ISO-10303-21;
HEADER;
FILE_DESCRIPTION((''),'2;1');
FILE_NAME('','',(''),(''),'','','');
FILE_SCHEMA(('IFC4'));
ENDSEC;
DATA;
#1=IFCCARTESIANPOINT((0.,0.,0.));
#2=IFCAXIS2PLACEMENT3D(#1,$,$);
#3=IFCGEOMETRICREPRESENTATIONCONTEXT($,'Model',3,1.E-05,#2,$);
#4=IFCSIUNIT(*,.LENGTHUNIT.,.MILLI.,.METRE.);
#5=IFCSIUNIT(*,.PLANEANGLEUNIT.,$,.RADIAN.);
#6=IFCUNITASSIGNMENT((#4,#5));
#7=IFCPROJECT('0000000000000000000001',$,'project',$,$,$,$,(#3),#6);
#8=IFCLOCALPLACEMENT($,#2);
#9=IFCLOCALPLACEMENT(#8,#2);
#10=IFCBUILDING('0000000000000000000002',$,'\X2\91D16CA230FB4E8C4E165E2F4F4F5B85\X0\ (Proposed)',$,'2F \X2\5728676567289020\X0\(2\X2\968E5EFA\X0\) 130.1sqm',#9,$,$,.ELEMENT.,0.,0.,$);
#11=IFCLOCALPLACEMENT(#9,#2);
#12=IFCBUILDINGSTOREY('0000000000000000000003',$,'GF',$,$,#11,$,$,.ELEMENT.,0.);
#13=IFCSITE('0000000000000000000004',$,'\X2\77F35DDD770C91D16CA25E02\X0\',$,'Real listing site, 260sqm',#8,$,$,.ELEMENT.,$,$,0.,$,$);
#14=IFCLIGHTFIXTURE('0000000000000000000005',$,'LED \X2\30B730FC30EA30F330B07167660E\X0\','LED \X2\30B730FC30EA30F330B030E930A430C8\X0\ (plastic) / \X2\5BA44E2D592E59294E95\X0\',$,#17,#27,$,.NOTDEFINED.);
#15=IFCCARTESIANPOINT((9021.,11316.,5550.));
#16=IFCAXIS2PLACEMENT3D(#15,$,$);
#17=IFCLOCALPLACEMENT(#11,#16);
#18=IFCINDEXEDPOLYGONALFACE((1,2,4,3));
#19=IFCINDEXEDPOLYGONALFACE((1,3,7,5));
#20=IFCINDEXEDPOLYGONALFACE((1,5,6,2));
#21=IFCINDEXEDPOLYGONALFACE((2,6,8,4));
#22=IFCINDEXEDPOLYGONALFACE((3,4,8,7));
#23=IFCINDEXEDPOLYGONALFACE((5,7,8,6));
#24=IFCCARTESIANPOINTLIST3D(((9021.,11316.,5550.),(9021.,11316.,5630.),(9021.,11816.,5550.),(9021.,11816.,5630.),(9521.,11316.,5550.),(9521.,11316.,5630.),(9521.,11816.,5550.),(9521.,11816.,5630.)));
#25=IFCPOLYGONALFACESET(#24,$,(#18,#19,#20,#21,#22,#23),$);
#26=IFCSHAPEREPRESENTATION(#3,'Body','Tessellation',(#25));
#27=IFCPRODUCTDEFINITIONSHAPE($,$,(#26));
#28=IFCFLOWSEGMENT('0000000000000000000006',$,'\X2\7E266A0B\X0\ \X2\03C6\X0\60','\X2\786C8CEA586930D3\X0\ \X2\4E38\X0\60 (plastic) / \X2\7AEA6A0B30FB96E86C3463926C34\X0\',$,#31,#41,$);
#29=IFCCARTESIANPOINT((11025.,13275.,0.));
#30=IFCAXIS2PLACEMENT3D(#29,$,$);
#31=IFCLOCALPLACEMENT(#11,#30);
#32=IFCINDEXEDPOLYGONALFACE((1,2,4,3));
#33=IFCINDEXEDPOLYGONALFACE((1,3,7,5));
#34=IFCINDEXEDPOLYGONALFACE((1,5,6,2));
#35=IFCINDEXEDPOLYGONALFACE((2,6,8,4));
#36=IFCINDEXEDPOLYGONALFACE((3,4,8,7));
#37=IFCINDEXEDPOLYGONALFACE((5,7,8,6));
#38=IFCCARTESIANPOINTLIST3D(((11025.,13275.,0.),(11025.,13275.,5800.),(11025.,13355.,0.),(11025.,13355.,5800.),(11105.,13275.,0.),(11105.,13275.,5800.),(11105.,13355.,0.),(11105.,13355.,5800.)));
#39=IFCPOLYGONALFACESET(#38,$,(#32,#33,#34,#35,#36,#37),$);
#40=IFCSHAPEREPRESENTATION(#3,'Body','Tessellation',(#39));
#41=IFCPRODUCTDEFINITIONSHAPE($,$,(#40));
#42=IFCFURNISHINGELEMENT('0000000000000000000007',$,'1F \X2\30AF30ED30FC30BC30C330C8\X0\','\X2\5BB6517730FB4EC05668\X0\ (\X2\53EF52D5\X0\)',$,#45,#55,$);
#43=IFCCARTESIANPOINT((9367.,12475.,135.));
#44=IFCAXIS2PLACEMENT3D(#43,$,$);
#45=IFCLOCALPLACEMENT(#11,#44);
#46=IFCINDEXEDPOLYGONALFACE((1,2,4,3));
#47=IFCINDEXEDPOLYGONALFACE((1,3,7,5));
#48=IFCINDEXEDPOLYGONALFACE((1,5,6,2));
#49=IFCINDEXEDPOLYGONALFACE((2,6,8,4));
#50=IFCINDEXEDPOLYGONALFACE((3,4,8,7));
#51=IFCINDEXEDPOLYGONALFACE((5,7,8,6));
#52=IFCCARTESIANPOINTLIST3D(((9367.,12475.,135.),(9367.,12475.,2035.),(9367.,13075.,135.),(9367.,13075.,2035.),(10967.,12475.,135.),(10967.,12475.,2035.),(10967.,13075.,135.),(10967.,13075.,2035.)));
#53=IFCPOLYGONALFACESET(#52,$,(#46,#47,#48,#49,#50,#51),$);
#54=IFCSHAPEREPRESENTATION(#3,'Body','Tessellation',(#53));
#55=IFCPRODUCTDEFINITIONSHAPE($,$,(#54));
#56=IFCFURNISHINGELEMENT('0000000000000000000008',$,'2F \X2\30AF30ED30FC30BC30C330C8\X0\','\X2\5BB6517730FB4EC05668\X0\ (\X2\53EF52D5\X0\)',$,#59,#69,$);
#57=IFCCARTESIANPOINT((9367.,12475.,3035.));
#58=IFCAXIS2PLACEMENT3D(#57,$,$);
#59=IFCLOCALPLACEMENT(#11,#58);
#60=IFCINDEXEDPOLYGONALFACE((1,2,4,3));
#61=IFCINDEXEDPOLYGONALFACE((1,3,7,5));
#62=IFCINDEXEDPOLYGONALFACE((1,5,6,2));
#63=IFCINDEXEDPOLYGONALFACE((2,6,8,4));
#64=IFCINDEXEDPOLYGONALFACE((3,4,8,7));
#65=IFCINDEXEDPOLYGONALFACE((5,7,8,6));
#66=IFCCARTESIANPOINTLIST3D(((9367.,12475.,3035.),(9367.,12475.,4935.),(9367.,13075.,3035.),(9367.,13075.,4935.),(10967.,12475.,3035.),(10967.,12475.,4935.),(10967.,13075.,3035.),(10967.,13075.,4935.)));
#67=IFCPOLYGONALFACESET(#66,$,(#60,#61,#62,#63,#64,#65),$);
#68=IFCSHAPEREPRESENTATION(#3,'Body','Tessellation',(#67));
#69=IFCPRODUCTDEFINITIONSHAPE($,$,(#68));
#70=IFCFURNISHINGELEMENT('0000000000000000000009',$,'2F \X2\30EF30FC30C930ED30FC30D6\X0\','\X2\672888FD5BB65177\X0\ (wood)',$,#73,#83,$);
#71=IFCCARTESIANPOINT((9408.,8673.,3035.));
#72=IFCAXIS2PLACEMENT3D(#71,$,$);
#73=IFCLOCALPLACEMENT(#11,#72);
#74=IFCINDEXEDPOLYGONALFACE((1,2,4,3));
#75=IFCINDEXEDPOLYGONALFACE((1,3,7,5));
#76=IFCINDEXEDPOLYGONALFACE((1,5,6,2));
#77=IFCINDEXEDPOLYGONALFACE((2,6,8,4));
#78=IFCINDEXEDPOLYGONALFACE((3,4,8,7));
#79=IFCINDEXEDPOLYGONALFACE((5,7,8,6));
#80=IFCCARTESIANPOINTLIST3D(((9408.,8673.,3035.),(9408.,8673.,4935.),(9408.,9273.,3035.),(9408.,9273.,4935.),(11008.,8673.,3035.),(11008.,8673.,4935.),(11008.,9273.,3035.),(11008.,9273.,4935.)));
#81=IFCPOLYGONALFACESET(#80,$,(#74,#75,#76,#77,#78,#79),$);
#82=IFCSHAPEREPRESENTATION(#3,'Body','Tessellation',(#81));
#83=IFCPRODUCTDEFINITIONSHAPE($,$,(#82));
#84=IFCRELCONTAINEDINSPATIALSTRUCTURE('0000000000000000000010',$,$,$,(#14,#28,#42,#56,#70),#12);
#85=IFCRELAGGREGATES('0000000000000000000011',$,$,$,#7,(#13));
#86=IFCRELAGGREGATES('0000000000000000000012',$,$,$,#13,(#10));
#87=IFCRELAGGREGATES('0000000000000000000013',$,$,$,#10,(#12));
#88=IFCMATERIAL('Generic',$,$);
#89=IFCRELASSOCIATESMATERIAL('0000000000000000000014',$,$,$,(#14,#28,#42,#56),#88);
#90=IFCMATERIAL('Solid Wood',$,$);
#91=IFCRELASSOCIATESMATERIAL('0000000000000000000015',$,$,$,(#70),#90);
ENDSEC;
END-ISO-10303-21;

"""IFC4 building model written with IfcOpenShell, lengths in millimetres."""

from ifc_helpers import new_model, si_unit, frame, frame_2d, origin, place, context, project, spatial, rectangle, extrude, material, element, save


model = new_model("IFC4")

# Units and contexts
model_context = context("Model", 3, precision=1e-05, world=origin())
ifc_project = project(units=[si_unit("LENGTHUNIT", "METRE", prefix="MILLI"), si_unit("PLANEANGLEUNIT", "RADIAN")], contexts=[model_context])

# Site, building, storey
site_placement = place(None, origin())
site = spatial("IfcSite", under=ifc_project, at=site_placement, Name="石川県金沢市", ObjectType="Real listing site, 260sqm", CompositionType="ELEMENT", RefElevation=0.0)
building_placement = place(site_placement, origin())
building = spatial("IfcBuilding", under=site, at=building_placement, Name="金沢・二世帯住宅 (Proposed)", ObjectType="2F 在来木造(2階建) 130.1sqm", CompositionType="ELEMENT", ElevationOfRefHeight=0.0, ElevationOfTerrain=0.0)
storey_placement = place(building_placement, origin())
storey = spatial("IfcBuildingStorey", under=building, at=storey_placement, Name="GF", CompositionType="ELEMENT", Elevation=0.0)

# Shared definitions
ifc_material_1 = material(Name="Solid Wood")

# Shared definitions
ifc_material_2 = material(Name="Generic")

# Light fixture
light_fixture_1_placement = place(storey_placement, frame((9021.0, 11316.0, 5550.0)))
element("IfcLightFixture", 1, at=light_fixture_1_placement, inside=storey, material=ifc_material_2, Name="LED シーリング照明", Description="LED シーリングライト (plastic) / 室中央天井", PredefinedType="NOTDEFINED", context=model_context, shape_type="SweptSolid", body=[
    extrude(rectangle(XDim=500.0, YDim=500.0, at=frame_2d((250.0, 250.0))), frame((9021.0, 11316.0, 5550.0)), (0.0, 0.0, 1.0), 80.0),
])

# Flow segment
flow_segment_placement = place(storey_placement, frame((11025.0, 13275.0, 0.0)))
element("IfcFlowSegment", 2, at=flow_segment_placement, inside=storey, material=ifc_material_2, Name="縦樋 φ60", Description="硬質塩ビ 丸60 (plastic) / 竪樋・雨水排水", context=model_context, shape_type="SweptSolid", body=[
    extrude(rectangle(XDim=80.0, YDim=80.0, at=frame_2d((40.0, 40.0))), frame((11025.0, 13275.0, 0.0)), (0.0, 0.0, 1.0), 5800.0),
])

# Furnishing elements
furnishing_1_placement = place(storey_placement, frame((9367.0, 12475.0, 135.0)))
element("IfcFurnishingElement", 3, at=furnishing_1_placement, inside=storey, material=ifc_material_2, Name="1F クローゼット", Description="家具・什器 (可動)", context=model_context, shape_type="SweptSolid", body=[
    extrude(rectangle(XDim=1600.0, YDim=600.0, at=frame_2d((800.0, 300.0))), frame((9367.0, 12475.0, 135.0)), (0.0, 0.0, 1.0), 1900.0),
])
furnishing_2_placement = place(storey_placement, frame((9367.0, 12475.0, 3035.0)))
element("IfcFurnishingElement", 4, at=furnishing_2_placement, inside=storey, material=ifc_material_2, Name="2F クローゼット", Description="家具・什器 (可動)", context=model_context, shape_type="SweptSolid", body=[
    extrude(rectangle(XDim=1600.0, YDim=600.0, at=frame_2d((800.0, 300.0))), frame((9367.0, 12475.0, 3035.0)), (0.0, 0.0, 1.0), 1900.0),
])
furnishing_3_placement = place(storey_placement, frame((9408.0, 8673.0, 3035.0)))
element("IfcFurnishingElement", 5, at=furnishing_3_placement, inside=storey, material=ifc_material_1, Name="2F ワードローブ", Description="木製家具 (wood)", context=model_context, shape_type="SweptSolid", body=[
    extrude(rectangle(XDim=1600.0, YDim=600.0, at=frame_2d((800.0, 300.0))), frame((9408.0, 8673.0, 3035.0)), (0.0, 0.0, 1.0), 1900.0),
])

save(model, "model.ifc")
